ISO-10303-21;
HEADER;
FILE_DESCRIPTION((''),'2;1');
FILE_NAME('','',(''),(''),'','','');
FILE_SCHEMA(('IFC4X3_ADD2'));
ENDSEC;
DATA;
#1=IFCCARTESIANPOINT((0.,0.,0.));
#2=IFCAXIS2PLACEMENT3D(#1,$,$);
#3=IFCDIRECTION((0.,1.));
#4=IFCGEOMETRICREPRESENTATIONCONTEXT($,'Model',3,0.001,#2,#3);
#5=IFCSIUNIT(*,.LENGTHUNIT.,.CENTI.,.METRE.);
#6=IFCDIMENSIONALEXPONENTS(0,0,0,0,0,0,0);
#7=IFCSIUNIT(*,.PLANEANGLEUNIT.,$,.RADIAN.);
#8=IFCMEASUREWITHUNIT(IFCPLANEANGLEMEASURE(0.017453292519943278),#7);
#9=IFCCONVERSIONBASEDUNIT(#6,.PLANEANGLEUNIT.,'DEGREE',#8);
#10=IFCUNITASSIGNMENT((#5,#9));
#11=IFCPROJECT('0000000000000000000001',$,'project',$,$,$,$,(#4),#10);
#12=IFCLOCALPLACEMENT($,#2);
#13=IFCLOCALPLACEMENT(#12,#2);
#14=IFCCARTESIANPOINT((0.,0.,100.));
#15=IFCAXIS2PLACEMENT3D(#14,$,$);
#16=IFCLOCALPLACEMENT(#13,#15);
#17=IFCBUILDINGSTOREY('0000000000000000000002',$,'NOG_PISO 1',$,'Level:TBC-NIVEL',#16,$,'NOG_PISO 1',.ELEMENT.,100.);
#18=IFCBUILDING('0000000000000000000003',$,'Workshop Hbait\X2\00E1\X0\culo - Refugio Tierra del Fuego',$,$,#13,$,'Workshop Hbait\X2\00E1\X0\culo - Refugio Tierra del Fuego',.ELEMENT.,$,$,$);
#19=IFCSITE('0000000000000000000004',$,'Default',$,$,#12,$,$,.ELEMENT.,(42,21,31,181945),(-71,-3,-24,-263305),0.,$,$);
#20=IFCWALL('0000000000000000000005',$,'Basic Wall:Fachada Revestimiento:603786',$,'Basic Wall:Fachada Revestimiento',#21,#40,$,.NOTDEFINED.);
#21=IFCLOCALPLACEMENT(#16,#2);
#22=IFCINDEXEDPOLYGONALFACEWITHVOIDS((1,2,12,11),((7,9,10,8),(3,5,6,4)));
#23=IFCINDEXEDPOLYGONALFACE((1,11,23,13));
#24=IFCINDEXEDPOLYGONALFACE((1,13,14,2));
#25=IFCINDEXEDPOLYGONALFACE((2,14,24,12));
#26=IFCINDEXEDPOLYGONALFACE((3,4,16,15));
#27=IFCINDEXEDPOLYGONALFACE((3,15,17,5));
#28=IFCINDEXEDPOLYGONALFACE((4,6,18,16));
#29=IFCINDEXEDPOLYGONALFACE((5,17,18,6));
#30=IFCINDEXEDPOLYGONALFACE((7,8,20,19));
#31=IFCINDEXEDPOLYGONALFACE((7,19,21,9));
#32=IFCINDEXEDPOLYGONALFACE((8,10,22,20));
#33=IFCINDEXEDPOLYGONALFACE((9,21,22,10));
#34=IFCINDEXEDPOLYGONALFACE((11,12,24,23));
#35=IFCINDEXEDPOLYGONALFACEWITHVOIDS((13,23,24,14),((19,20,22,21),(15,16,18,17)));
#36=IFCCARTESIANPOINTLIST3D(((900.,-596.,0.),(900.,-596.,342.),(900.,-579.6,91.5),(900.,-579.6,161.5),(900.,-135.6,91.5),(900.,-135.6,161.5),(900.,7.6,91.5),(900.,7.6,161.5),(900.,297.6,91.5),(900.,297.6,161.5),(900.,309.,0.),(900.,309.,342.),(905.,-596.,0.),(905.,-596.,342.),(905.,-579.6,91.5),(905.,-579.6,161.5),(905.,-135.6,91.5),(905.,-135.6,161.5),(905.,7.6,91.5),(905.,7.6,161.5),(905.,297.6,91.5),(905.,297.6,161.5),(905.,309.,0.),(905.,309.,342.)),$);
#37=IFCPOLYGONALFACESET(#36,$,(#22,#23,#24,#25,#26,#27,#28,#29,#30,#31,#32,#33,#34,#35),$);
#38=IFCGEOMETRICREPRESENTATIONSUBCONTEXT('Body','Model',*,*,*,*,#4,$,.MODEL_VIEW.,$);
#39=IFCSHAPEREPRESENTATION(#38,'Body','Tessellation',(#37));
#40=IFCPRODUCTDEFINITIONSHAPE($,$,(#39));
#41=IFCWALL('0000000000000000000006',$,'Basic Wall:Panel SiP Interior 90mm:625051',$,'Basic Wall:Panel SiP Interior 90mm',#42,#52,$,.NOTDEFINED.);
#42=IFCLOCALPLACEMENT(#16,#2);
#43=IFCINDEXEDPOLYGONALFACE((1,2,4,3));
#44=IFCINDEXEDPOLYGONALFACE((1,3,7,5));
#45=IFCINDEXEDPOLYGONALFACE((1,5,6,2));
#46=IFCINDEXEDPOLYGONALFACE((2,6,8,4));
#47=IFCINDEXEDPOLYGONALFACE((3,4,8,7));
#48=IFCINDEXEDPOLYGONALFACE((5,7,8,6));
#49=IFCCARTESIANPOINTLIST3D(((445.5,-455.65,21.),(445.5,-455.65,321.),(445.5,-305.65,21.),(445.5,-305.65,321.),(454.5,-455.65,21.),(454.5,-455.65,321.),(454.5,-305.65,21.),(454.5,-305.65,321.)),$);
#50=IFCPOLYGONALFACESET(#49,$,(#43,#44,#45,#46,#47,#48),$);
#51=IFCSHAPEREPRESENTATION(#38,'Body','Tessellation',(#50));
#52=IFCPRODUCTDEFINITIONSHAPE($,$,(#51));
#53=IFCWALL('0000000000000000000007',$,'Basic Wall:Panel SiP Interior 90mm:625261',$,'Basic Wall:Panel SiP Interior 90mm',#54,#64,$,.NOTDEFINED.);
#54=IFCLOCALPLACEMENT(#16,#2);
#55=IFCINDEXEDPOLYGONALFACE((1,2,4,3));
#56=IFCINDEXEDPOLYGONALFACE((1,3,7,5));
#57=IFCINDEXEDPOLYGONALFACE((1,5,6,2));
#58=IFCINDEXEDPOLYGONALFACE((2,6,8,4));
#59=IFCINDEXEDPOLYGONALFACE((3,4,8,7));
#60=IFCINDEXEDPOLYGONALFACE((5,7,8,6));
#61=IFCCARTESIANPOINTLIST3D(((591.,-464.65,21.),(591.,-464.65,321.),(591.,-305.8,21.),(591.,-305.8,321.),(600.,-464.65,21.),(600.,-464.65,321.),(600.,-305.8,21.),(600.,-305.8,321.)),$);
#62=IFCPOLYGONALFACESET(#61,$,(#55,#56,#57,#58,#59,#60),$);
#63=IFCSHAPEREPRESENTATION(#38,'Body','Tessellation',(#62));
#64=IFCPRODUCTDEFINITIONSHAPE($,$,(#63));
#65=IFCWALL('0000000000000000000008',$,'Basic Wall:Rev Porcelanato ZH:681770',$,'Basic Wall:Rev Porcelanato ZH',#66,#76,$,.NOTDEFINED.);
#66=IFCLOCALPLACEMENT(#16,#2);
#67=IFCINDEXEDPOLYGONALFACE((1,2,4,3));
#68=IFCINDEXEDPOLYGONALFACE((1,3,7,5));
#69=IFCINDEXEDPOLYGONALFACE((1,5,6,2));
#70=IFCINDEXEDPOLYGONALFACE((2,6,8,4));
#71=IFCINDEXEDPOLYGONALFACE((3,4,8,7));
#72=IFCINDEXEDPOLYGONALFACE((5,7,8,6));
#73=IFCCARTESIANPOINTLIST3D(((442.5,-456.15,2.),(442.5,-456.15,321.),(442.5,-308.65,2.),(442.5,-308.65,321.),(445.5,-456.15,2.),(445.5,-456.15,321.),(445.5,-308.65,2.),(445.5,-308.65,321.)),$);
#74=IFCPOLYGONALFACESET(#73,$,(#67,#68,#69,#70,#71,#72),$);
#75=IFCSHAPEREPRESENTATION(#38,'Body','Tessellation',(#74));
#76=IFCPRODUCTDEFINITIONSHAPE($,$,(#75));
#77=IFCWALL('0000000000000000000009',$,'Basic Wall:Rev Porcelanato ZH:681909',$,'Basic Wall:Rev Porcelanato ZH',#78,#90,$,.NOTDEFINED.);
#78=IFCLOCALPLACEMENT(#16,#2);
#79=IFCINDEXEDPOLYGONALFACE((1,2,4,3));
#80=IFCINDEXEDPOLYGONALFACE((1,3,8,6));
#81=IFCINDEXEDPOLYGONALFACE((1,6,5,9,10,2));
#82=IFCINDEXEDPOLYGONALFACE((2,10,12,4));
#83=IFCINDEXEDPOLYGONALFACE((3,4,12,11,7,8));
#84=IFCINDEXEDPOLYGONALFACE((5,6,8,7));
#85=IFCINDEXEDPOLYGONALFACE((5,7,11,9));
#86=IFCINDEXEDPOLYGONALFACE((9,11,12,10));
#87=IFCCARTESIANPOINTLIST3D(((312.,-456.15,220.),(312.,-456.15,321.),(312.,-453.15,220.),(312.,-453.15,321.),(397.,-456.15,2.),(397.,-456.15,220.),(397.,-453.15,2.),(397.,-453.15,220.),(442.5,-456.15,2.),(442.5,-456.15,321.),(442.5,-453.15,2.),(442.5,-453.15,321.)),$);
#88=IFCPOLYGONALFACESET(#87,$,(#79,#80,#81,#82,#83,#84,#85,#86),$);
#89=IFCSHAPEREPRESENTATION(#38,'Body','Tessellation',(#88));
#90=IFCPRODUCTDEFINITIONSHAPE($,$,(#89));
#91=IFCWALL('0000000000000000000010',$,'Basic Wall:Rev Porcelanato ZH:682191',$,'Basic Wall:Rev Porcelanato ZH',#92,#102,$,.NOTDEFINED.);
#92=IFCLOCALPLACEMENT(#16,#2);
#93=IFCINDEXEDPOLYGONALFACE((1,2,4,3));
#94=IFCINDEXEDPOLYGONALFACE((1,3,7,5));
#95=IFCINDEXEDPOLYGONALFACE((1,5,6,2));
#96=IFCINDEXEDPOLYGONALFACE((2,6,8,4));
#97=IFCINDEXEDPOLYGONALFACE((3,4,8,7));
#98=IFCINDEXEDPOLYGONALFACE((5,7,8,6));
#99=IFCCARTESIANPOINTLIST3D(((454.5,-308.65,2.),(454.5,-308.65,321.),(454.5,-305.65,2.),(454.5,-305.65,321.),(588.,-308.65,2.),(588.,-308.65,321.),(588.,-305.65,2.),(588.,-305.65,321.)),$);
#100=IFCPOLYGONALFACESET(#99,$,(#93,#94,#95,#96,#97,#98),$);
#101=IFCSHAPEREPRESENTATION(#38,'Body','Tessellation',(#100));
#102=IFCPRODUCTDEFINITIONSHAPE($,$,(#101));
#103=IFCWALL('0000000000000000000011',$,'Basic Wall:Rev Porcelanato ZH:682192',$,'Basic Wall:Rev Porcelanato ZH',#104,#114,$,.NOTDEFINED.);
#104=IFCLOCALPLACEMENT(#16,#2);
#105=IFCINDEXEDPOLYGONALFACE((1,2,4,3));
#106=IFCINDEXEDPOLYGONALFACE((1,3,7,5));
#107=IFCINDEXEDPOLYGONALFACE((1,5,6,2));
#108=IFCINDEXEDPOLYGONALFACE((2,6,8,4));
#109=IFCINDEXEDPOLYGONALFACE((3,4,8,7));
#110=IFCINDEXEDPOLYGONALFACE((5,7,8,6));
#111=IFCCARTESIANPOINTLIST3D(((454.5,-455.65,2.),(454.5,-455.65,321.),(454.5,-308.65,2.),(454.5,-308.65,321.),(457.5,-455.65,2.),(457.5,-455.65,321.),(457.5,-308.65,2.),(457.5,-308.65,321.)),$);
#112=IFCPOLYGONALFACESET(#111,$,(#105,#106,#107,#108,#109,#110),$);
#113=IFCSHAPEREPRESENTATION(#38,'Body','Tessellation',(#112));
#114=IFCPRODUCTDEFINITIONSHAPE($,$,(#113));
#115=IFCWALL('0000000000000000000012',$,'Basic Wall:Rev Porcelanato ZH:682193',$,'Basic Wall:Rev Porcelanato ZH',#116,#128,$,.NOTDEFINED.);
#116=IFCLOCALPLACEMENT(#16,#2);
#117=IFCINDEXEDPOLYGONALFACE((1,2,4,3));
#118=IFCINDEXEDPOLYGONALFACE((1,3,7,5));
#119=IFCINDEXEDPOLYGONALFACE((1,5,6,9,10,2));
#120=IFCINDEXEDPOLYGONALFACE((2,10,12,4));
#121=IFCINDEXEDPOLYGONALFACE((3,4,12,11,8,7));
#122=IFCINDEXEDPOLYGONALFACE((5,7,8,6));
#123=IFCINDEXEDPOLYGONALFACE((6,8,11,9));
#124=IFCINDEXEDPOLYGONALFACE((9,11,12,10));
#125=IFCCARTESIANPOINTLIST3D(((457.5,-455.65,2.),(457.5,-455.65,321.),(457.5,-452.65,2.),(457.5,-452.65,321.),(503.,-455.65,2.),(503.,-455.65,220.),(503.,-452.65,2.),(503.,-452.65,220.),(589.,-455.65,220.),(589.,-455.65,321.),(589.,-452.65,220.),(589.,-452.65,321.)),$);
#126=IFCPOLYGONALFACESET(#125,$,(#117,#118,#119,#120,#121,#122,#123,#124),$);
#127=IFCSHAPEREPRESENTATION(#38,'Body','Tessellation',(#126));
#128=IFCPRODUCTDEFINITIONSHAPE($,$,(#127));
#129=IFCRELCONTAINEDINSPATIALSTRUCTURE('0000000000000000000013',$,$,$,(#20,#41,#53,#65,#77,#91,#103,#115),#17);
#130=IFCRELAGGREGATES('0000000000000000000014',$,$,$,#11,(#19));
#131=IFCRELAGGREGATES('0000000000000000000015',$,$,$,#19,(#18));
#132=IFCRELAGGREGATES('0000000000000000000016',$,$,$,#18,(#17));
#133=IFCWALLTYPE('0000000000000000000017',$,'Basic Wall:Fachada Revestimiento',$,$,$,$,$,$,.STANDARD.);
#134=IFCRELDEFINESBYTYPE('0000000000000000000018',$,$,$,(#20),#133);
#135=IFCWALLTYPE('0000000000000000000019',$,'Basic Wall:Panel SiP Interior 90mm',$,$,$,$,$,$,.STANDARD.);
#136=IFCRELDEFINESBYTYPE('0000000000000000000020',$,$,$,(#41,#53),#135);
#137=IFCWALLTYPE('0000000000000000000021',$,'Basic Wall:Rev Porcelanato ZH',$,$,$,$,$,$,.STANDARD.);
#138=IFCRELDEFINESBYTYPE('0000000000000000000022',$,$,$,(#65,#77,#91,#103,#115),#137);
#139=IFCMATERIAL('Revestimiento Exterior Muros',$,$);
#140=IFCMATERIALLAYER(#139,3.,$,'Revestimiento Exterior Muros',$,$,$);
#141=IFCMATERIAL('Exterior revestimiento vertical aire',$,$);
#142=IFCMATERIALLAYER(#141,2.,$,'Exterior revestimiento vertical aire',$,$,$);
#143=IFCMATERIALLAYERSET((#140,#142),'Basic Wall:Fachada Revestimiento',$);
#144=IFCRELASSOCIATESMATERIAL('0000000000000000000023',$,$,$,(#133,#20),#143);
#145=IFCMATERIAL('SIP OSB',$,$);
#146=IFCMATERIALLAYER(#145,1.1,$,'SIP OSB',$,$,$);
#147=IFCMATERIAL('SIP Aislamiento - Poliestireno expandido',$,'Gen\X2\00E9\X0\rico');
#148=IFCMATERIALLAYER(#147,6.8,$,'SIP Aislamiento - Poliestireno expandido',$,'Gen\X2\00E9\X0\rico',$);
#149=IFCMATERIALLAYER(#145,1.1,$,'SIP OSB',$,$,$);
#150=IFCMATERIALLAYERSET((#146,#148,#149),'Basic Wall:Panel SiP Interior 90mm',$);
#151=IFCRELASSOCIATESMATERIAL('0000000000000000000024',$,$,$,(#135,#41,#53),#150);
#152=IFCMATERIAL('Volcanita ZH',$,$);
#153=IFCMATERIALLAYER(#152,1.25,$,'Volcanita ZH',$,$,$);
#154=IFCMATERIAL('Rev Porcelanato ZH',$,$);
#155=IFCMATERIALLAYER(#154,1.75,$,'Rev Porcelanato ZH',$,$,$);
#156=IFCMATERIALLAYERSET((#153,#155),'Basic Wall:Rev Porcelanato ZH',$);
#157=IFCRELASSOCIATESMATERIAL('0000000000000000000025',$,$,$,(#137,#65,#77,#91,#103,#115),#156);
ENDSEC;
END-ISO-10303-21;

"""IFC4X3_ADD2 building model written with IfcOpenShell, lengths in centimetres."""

from ifc_helpers import new_model, entity, si_unit, converted_unit, direction, frame, frame_2d, origin, place, context, subcontext, project, spatial, rectangle, extrude, material, layer, layer_set, type_object, element, save


model = new_model("IFC4X3_ADD2")

# Units and contexts
model_context = context("Model", 3, precision=0.001, world=origin(), true_north=direction((0.0, 1.0)))
body_context = subcontext(model_context, "Body", "Model", "MODEL_VIEW")
ifc_project = project(units=[si_unit("LENGTHUNIT", "METRE", prefix="CENTI"), converted_unit("PLANEANGLEUNIT", "DEGREE", entity("IfcPlaneAngleMeasure", 0.017453292519943278), si_unit("PLANEANGLEUNIT", "RADIAN"), dimensions=[0, 0, 0, 0, 0, 0, 0])], contexts=[model_context])

# Site, building, storey
site_placement = place(None, origin())
site = spatial("IfcSite", under=ifc_project, at=site_placement, Name="Default", CompositionType="ELEMENT", RefLatitude=(42, 21, 31, 181945), RefLongitude=(-71, -3, -24, -263305), RefElevation=0.0)
building_placement = place(site_placement, origin())
building = spatial("IfcBuilding", under=site, at=building_placement, Name="Workshop Hbaitáculo - Refugio Tierra del Fuego", LongName="Workshop Hbaitáculo - Refugio Tierra del Fuego", CompositionType="ELEMENT")
storey_placement = place(building_placement, frame((0.0, 0.0, 100.0)))
storey = spatial("IfcBuildingStorey", under=building, at=storey_placement, Name="NOG_PISO 1", ObjectType="Level:TBC-NIVEL", LongName="NOG_PISO 1", CompositionType="ELEMENT", Elevation=100.0)

# Wall, openings
ifc_material_1 = material(Name="Revestimiento Exterior Muros")
ifc_layer_1 = layer(ifc_material_1, 3.0, Name="Revestimiento Exterior Muros")
ifc_material_2 = material(Name="Exterior revestimiento vertical aire")
ifc_layer_2 = layer(ifc_material_2, 2.0, Name="Exterior revestimiento vertical aire")
ifc_layer_set_1 = layer_set([ifc_layer_1, ifc_layer_2], Name="Basic Wall:Fachada Revestimiento")
wall_type_1 = type_object("IfcWallType", Name="Basic Wall:Fachada Revestimiento", PredefinedType="STANDARD", material=ifc_layer_set_1)
wall_1_placement = place(storey_placement, frame((902.5, -596.0, 0.0), z_axis=(0.0, 0.0, 1.0), x_axis=(0.0, 1.0, 0.0)))
wall_1 = element("IfcWall", 1, at=wall_1_placement, inside=storey, type_object=wall_type_1, material=ifc_layer_set_1, Name="Basic Wall:Fachada Revestimiento:603786", ObjectType="Basic Wall:Fachada Revestimiento", PredefinedType="NOTDEFINED", context=body_context, shape_type="SweptSolid", body=[
    extrude(rectangle(XDim=905.0, YDim=5.0, at=frame_2d((452.5, 0.0), x_axis=(-1.0, 0.0))), origin(), (0.0, 0.0, 1.0), 342.0),
])
opening_1_placement = place(wall_1_placement, origin())
element("IfcOpeningElement", 2, at=opening_1_placement, cuts=wall_1, PredefinedType="OPENING", context=body_context, shape_type="SweptSolid", body=[
    extrude(rectangle(XDim=70.0, YDim=444.0, at=frame_2d((0.0, 0.0), x_axis=(0.0, 1.0))), frame((238.4, 2.5, 126.5), z_axis=(0.0, -1.0, 0.0), x_axis=(-1.0, 0.0, 0.0)), (0.0, 0.0, 1.0), 5.0),
])
opening_2_placement = place(wall_1_placement, origin())
element("IfcOpeningElement", 3, at=opening_2_placement, cuts=wall_1, PredefinedType="OPENING", context=body_context, shape_type="SweptSolid", body=[
    extrude(rectangle(XDim=70.0, YDim=290.0, at=frame_2d((0.0, 0.0), x_axis=(1.0, 0.0))), frame((748.6, 2.5, 126.5), z_axis=(0.0, -1.0, 0.0), x_axis=(0.0, 0.0, 1.0)), (0.0, 0.0, 1.0), 5.0),
])

# Walls
ifc_material_3 = material(Name="SIP OSB")
ifc_layer_3 = layer(ifc_material_3, 1.1, Name="SIP OSB")
ifc_material_4 = material(Name="SIP Aislamiento - Poliestireno expandido", Category="Genérico")
ifc_layer_4 = layer(ifc_material_4, 6.8, Name="SIP Aislamiento - Poliestireno expandido", Category="Genérico")
ifc_layer_5 = layer(ifc_material_3, 1.1, Name="SIP OSB")
ifc_layer_set_2 = layer_set([ifc_layer_3, ifc_layer_4, ifc_layer_5], Name="Basic Wall:Panel SiP Interior 90mm")
wall_type_2 = type_object("IfcWallType", Name="Basic Wall:Panel SiP Interior 90mm", PredefinedType="STANDARD", material=ifc_layer_set_2)
wall_2_placement = place(storey_placement, frame((450.0, -455.65, 21.0), z_axis=(0.0, 0.0, 1.0), x_axis=(0.0, 1.0, 0.0)))
element("IfcWall", 4, at=wall_2_placement, inside=storey, type_object=wall_type_2, material=ifc_layer_set_2, Name="Basic Wall:Panel SiP Interior 90mm:625051", ObjectType="Basic Wall:Panel SiP Interior 90mm", PredefinedType="NOTDEFINED", context=body_context, shape_type="SweptSolid", body=[
    extrude(rectangle(XDim=150.0, YDim=9.0, at=frame_2d((75.0, 0.0), x_axis=(-1.0, 0.0))), origin(), (0.0, 0.0, 1.0), 300.0),
])
wall_3_placement = place(storey_placement, frame((595.5, -305.8, 21.0), z_axis=(0.0, 0.0, 1.0), x_axis=(0.0, -1.0, 0.0)))
element("IfcWall", 5, at=wall_3_placement, inside=storey, type_object=wall_type_2, material=ifc_layer_set_2, Name="Basic Wall:Panel SiP Interior 90mm:625261", ObjectType="Basic Wall:Panel SiP Interior 90mm", PredefinedType="NOTDEFINED", context=body_context, shape_type="SweptSolid", body=[
    extrude(rectangle(XDim=158.85, YDim=9.0, at=frame_2d((79.43, 0.0), x_axis=(-1.0, 0.0))), origin(), (0.0, 0.0, 1.0), 300.0),
])
ifc_material_5 = material(Name="Volcanita ZH")
ifc_layer_6 = layer(ifc_material_5, 1.25, Name="Volcanita ZH")
ifc_material_6 = material(Name="Rev Porcelanato ZH")
ifc_layer_7 = layer(ifc_material_6, 1.75, Name="Rev Porcelanato ZH")
ifc_layer_set_3 = layer_set([ifc_layer_6, ifc_layer_7], Name="Basic Wall:Rev Porcelanato ZH")
wall_type_3 = type_object("IfcWallType", Name="Basic Wall:Rev Porcelanato ZH", PredefinedType="STANDARD", material=ifc_layer_set_3)
wall_4_placement = place(storey_placement, frame((444.0, -308.65, 2.0), z_axis=(0.0, 0.0, 1.0), x_axis=(0.0, -1.0, 0.0)))
element("IfcWall", 6, at=wall_4_placement, inside=storey, type_object=wall_type_3, material=ifc_layer_set_3, Name="Basic Wall:Rev Porcelanato ZH:681770", ObjectType="Basic Wall:Rev Porcelanato ZH", PredefinedType="NOTDEFINED", context=body_context, shape_type="SweptSolid", body=[
    extrude(rectangle(XDim=147.5, YDim=3.0, at=frame_2d((73.75, 0.0), x_axis=(-1.0, 0.0))), origin(), (0.0, 0.0, 1.0), 319.0),
])

# Wall, opening
wall_5_placement = place(storey_placement, frame((442.5, -454.65, 2.0), z_axis=(0.0, 0.0, 1.0), x_axis=(-1.0, 0.0, 0.0)))
wall_5 = element("IfcWall", 7, at=wall_5_placement, inside=storey, type_object=wall_type_3, material=ifc_layer_set_3, Name="Basic Wall:Rev Porcelanato ZH:681909", ObjectType="Basic Wall:Rev Porcelanato ZH", PredefinedType="NOTDEFINED", context=body_context, shape_type="SweptSolid", body=[
    extrude(rectangle(XDim=130.5, YDim=3.0, at=frame_2d((65.25, 0.0), x_axis=(-1.0, 0.0))), origin(), (0.0, 0.0, 1.0), 319.0),
])
opening_3_placement = place(wall_5_placement, origin())
element("IfcOpeningElement", 8, at=opening_3_placement, cuts=wall_5, PredefinedType="OPENING", context=body_context, shape_type="SweptSolid", body=[
    extrude(rectangle(XDim=218.0, YDim=85.0, at=frame_2d((0.0, 0.0), x_axis=(0.0, 1.0))), frame((88.0, 1.5, 109.0), z_axis=(0.0, -1.0, 0.0), x_axis=(1.0, 0.0, 0.0)), (0.0, 0.0, 1.0), 3.0),
])

# Walls
wall_6_placement = place(storey_placement, frame((588.0, -307.15, 2.0), z_axis=(0.0, 0.0, 1.0), x_axis=(-1.0, 0.0, 0.0)))
element("IfcWall", 9, at=wall_6_placement, inside=storey, type_object=wall_type_3, material=ifc_layer_set_3, Name="Basic Wall:Rev Porcelanato ZH:682191", ObjectType="Basic Wall:Rev Porcelanato ZH", PredefinedType="NOTDEFINED", context=body_context, shape_type="SweptSolid", body=[
    extrude(rectangle(XDim=133.5, YDim=3.0, at=frame_2d((66.75, 0.0), x_axis=(-1.0, 0.0))), origin(), (0.0, 0.0, 1.0), 319.0),
])
wall_7_placement = place(storey_placement, frame((456.0, -308.65, 2.0), z_axis=(0.0, 0.0, 1.0), x_axis=(0.0, -1.0, 0.0)))
element("IfcWall", 10, at=wall_7_placement, inside=storey, type_object=wall_type_3, material=ifc_layer_set_3, Name="Basic Wall:Rev Porcelanato ZH:682192", ObjectType="Basic Wall:Rev Porcelanato ZH", PredefinedType="NOTDEFINED", context=body_context, shape_type="SweptSolid", body=[
    extrude(rectangle(XDim=147.0, YDim=3.0, at=frame_2d((73.5, 0.0), x_axis=(-1.0, 0.0))), origin(), (0.0, 0.0, 1.0), 319.0),
])

# Wall, opening
wall_8_placement = place(storey_placement, frame((457.5, -454.15, 2.0)))
wall_8 = element("IfcWall", 11, at=wall_8_placement, inside=storey, type_object=wall_type_3, material=ifc_layer_set_3, Name="Basic Wall:Rev Porcelanato ZH:682193", ObjectType="Basic Wall:Rev Porcelanato ZH", PredefinedType="NOTDEFINED", context=body_context, shape_type="SweptSolid", body=[
    extrude(rectangle(XDim=131.5, YDim=3.0, at=frame_2d((65.75, 0.0), x_axis=(-1.0, 0.0))), origin(), (0.0, 0.0, 1.0), 319.0),
])
opening_4_placement = place(wall_8_placement, origin())
element("IfcOpeningElement", 12, at=opening_4_placement, cuts=wall_8, PredefinedType="OPENING", context=body_context, shape_type="SweptSolid", body=[
    extrude(rectangle(XDim=218.0, YDim=86.0, at=frame_2d((0.0, 0.0), x_axis=(0.0, 1.0))), frame((88.5, 1.5, 109.0), z_axis=(0.0, -1.0, 0.0), x_axis=(1.0, 0.0, 0.0)), (0.0, 0.0, 1.0), 3.0),
])

save(model, "model.ifc")
